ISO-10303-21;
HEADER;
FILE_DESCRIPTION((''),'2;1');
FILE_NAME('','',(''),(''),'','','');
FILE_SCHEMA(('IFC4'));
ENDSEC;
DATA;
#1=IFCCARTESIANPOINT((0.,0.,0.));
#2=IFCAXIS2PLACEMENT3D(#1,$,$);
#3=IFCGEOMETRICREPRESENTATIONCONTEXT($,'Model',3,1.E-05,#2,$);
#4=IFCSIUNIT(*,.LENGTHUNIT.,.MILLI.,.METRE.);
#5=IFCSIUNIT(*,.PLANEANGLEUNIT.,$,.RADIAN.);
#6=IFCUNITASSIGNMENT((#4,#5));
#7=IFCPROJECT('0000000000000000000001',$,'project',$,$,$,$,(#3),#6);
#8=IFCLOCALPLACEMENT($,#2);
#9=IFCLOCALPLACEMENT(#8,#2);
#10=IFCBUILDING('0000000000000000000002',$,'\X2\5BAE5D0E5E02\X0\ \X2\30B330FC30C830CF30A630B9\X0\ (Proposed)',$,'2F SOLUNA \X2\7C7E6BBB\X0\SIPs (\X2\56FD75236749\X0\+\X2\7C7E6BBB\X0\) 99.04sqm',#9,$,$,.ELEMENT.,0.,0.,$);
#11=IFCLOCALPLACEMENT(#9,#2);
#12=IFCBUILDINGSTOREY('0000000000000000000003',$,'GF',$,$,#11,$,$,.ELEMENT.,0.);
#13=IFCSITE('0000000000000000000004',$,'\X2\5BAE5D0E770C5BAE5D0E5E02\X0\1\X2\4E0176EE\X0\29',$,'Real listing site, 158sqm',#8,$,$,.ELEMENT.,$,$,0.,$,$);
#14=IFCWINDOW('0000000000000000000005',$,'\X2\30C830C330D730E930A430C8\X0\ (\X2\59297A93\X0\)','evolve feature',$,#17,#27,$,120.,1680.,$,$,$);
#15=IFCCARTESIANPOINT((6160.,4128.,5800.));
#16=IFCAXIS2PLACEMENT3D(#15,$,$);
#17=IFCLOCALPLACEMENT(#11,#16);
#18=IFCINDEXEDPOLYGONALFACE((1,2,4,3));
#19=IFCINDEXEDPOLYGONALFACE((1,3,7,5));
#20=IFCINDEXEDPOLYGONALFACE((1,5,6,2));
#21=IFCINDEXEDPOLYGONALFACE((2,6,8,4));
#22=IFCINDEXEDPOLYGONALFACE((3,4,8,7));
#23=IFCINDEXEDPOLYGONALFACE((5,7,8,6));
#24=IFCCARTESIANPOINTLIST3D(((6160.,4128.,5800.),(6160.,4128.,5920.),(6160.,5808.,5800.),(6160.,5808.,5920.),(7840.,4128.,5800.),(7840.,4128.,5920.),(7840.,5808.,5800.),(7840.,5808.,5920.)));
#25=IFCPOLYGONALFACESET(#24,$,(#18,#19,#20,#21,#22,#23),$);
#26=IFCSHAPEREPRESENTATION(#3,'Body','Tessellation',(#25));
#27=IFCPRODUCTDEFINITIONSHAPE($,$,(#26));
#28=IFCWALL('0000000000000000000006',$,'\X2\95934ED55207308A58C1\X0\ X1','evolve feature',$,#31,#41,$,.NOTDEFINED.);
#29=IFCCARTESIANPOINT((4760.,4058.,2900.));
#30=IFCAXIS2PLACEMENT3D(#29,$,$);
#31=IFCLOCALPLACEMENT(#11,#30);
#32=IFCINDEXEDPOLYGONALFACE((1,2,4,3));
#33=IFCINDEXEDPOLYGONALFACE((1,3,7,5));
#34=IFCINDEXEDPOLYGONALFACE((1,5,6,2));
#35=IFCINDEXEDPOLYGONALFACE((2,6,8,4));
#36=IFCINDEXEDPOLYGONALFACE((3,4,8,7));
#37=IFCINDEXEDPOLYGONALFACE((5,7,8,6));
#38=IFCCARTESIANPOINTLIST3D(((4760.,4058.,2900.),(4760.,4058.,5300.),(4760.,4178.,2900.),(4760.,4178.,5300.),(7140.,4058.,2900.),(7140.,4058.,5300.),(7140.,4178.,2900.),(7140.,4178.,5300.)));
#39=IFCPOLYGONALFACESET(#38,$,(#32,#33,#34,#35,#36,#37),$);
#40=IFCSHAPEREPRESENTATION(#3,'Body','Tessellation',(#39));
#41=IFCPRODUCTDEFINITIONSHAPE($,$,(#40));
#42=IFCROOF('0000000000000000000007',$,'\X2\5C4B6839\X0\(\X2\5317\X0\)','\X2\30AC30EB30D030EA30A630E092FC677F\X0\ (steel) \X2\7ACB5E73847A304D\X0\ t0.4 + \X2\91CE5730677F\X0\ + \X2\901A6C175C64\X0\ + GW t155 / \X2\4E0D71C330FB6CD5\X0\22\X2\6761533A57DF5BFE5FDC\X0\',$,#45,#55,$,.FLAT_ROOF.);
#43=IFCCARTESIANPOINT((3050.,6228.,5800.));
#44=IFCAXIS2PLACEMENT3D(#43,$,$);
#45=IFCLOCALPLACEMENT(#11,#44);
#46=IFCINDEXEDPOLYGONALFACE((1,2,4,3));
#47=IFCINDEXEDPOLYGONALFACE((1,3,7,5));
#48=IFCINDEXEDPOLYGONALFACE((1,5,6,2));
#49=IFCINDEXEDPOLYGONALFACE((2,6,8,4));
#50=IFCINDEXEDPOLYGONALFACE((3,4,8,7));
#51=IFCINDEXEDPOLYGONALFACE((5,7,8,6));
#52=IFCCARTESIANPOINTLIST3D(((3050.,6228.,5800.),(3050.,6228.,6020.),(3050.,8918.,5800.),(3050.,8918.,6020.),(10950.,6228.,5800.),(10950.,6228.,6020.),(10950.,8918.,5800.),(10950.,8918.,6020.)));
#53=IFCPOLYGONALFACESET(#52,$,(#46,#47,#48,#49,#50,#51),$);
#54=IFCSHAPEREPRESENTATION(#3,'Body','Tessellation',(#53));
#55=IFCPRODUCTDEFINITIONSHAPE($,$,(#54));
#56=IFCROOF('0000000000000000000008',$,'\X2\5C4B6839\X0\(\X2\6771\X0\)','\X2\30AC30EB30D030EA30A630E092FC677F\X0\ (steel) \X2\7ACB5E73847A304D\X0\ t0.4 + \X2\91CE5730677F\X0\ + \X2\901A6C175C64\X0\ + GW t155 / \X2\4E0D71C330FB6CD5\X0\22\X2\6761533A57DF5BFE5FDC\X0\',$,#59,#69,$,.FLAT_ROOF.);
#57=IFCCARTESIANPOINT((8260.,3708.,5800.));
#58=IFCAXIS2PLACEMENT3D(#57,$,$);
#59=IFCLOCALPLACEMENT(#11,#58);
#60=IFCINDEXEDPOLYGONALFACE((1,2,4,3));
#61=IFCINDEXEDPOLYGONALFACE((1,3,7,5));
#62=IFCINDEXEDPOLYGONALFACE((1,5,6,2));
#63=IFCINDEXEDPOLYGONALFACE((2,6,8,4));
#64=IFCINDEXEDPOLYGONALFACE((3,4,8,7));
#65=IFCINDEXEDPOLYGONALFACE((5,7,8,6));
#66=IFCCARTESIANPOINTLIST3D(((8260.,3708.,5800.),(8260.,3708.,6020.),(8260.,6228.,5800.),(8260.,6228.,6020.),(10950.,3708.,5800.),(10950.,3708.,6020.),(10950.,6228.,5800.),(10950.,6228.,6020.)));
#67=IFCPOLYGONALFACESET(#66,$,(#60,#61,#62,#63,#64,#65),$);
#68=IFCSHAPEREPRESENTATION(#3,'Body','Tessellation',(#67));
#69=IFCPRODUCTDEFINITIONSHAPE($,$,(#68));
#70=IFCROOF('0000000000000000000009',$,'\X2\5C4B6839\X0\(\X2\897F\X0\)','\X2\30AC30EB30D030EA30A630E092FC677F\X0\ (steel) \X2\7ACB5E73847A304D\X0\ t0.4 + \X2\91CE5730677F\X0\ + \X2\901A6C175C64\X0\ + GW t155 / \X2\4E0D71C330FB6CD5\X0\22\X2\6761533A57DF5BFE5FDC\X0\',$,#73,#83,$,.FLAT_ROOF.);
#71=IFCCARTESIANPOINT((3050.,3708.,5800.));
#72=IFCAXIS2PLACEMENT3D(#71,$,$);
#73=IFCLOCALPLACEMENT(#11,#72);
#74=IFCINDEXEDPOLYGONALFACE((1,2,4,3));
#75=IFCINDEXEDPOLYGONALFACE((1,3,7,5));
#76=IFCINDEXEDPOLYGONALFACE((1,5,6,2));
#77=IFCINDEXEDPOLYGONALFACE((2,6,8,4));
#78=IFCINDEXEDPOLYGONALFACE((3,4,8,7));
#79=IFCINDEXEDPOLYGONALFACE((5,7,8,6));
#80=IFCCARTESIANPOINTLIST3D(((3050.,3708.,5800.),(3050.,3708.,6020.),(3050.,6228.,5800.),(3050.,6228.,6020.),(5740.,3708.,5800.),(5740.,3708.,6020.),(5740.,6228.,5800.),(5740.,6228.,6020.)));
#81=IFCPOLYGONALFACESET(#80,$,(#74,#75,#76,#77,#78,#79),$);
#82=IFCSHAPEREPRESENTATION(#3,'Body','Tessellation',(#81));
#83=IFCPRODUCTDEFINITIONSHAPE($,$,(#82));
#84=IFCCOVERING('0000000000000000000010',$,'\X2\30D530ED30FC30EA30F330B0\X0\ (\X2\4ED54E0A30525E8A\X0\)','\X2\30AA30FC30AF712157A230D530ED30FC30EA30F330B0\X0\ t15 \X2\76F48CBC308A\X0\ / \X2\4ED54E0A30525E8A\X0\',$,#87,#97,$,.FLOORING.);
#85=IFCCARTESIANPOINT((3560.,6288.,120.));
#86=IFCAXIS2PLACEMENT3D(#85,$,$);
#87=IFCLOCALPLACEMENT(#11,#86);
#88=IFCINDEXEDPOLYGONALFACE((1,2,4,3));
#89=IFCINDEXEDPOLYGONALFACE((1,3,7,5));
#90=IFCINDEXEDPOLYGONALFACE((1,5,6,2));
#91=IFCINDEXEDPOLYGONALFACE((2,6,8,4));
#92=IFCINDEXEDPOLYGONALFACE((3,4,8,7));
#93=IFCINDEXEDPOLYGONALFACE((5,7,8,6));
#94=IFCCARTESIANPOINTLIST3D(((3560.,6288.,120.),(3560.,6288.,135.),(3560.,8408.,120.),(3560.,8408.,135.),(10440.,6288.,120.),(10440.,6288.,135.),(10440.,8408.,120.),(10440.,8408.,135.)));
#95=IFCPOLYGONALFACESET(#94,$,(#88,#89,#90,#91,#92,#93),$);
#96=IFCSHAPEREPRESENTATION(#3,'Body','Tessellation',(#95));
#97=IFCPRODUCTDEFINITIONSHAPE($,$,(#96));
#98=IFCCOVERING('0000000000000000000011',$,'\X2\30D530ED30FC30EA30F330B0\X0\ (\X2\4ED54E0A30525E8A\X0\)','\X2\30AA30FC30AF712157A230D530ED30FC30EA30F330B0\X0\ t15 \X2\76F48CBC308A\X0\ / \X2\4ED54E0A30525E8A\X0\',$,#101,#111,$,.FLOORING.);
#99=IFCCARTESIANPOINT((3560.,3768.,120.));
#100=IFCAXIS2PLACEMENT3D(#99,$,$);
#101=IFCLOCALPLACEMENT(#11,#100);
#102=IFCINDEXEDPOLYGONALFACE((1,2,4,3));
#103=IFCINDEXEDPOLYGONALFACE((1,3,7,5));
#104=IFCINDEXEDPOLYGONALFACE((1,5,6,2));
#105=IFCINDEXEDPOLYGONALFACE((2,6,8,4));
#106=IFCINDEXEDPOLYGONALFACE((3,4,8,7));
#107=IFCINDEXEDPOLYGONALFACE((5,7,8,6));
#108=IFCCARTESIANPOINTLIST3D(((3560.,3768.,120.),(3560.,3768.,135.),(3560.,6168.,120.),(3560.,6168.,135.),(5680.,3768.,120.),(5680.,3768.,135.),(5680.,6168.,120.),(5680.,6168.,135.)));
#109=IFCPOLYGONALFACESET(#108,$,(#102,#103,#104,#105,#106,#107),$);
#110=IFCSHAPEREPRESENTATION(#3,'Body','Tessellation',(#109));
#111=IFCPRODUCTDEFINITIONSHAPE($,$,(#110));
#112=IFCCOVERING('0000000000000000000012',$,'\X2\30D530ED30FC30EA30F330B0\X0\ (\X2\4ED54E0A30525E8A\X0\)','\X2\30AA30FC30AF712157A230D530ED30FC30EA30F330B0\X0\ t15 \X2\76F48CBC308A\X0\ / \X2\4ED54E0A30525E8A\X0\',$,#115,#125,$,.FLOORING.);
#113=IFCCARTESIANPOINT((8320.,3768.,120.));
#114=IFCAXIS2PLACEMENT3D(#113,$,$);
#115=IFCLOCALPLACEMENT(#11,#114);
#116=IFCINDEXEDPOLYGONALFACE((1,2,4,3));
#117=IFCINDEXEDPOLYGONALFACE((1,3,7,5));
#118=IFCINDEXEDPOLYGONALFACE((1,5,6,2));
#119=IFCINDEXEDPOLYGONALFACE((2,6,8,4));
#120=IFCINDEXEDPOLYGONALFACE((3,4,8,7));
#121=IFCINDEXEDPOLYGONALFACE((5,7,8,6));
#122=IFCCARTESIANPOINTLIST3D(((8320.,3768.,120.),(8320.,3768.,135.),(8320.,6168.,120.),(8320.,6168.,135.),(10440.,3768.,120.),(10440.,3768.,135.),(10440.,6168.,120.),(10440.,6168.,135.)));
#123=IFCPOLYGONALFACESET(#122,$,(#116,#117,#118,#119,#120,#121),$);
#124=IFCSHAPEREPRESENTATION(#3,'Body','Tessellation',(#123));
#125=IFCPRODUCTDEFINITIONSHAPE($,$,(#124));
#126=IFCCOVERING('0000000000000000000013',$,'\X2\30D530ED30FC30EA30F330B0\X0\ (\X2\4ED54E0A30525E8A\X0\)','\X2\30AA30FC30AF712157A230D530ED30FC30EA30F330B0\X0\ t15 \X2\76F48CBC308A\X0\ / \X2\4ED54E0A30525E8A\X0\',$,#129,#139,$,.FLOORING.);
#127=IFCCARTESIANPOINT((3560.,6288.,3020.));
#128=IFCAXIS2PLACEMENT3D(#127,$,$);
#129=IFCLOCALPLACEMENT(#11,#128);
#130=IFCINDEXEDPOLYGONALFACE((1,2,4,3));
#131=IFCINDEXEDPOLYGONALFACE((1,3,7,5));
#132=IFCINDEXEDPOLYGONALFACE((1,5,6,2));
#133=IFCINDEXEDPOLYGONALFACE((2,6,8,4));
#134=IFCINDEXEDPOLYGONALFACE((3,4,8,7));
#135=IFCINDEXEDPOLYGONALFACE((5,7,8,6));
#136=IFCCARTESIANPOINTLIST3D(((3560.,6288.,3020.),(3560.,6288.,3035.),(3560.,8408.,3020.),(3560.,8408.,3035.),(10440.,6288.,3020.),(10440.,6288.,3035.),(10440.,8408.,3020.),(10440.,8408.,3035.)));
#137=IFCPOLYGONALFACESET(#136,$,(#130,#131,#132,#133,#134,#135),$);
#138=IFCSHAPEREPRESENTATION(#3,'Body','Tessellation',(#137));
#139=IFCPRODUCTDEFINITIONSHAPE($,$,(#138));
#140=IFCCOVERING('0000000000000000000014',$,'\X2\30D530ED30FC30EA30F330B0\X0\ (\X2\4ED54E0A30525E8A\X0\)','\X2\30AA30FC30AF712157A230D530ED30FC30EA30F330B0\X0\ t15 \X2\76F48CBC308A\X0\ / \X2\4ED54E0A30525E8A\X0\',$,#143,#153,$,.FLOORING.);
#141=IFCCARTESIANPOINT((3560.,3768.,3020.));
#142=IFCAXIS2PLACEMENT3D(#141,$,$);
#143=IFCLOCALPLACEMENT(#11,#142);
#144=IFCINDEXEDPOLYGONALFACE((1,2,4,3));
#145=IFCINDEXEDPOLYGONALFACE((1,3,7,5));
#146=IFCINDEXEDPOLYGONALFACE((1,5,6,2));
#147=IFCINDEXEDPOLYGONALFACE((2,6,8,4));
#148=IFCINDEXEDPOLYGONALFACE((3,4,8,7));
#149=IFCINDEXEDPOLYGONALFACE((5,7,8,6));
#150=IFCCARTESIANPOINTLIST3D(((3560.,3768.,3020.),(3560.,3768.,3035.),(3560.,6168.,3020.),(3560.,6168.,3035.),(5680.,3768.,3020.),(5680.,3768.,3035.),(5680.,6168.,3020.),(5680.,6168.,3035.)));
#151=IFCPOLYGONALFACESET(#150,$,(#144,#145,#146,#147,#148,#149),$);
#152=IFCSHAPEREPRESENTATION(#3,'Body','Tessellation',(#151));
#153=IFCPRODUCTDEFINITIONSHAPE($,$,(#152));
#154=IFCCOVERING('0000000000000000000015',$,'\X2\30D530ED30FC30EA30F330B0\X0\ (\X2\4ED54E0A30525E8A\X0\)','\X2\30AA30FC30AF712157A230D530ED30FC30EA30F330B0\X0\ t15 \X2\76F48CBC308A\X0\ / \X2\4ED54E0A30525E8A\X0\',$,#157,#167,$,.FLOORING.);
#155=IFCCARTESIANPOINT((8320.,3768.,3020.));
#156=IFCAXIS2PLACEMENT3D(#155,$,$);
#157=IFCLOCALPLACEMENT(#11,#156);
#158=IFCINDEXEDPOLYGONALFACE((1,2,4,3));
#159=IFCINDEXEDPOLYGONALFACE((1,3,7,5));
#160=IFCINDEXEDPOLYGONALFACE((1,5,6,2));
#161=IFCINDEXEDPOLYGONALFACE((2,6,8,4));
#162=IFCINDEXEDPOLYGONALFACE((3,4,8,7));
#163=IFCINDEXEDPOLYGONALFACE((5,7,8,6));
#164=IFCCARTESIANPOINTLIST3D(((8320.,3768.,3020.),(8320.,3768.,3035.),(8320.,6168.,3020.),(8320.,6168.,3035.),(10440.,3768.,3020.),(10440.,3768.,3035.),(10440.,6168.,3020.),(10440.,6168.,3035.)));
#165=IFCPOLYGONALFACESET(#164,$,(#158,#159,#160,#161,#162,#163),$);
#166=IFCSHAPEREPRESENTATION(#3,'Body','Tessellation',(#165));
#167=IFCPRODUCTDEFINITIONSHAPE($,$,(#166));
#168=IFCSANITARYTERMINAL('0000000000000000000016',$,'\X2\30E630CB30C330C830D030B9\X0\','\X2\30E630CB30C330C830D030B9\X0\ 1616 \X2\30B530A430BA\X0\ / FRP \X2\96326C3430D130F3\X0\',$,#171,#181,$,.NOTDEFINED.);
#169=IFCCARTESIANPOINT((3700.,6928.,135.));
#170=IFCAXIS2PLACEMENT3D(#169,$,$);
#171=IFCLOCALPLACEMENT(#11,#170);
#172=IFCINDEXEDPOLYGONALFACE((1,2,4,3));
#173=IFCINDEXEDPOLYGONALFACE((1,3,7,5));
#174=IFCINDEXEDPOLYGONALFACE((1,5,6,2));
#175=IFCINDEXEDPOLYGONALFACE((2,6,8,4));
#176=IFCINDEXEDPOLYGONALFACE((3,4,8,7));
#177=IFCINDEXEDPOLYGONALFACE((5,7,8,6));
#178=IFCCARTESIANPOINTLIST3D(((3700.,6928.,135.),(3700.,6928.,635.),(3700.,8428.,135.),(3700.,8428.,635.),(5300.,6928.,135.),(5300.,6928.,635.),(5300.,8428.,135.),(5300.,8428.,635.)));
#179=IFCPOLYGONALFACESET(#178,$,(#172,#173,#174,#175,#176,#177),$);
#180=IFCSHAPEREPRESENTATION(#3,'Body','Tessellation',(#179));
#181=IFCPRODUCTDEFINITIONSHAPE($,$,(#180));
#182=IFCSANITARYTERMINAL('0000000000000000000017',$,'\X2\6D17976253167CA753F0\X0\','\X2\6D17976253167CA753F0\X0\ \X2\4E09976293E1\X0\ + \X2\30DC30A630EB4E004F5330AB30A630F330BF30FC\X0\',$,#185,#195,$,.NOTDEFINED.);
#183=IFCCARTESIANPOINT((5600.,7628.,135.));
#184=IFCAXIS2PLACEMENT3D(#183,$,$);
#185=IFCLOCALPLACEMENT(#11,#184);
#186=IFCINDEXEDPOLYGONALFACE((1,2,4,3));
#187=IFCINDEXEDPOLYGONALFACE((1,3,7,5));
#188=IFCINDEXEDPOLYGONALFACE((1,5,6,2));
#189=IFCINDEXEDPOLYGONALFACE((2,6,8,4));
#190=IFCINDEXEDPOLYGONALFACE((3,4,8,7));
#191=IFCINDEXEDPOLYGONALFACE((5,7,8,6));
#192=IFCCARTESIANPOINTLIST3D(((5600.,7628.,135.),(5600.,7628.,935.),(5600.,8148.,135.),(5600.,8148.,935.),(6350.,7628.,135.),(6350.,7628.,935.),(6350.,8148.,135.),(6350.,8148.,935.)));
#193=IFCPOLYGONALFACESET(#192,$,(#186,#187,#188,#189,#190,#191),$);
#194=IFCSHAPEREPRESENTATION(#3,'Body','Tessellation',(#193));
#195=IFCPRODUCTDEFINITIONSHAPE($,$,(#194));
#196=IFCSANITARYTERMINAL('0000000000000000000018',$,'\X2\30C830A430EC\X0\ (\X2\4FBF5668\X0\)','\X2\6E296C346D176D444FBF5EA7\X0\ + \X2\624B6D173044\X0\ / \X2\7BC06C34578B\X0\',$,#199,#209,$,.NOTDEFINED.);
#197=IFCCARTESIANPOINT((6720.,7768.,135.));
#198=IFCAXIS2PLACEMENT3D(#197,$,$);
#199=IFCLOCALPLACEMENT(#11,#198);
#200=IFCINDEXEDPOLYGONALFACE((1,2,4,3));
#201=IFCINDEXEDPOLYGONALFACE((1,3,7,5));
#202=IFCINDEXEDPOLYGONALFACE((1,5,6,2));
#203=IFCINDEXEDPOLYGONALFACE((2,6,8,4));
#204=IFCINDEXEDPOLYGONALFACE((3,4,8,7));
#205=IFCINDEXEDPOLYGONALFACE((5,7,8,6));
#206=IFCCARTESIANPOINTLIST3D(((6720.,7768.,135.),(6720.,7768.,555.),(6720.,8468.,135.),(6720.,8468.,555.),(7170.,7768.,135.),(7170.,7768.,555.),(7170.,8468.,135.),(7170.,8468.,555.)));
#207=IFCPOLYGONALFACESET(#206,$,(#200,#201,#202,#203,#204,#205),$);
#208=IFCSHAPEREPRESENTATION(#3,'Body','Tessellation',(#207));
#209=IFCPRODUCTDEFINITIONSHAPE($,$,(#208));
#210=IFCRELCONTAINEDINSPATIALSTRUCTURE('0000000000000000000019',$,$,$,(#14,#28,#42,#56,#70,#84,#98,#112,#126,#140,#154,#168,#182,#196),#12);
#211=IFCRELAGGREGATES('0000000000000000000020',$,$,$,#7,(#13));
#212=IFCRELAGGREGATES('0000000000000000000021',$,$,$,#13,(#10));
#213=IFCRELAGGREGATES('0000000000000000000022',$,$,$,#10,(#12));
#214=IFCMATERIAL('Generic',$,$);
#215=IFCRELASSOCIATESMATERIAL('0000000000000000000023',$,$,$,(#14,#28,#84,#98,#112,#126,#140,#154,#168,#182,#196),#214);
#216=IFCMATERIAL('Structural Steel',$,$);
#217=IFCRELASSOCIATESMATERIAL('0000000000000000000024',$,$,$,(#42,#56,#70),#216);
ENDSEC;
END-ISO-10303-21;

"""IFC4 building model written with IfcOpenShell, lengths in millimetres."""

from ifc_helpers import new_model, si_unit, frame, frame_2d, origin, place, context, project, spatial, rectangle, extrude, material, element, save


model = new_model("IFC4")

# Units and contexts
model_context = context("Model", 3, precision=1e-05, world=origin())
ifc_project = project(units=[si_unit("LENGTHUNIT", "METRE", prefix="MILLI"), si_unit("PLANEANGLEUNIT", "RADIAN")], contexts=[model_context])

# Site, building, storey
site_placement = place(None, origin())
site = spatial("IfcSite", under=ifc_project, at=site_placement, Name="宮崎県宮崎市1丁目29", ObjectType="Real listing site, 158sqm", CompositionType="ELEMENT", RefElevation=0.0)
building_placement = place(site_placement, origin())
building = spatial("IfcBuilding", under=site, at=building_placement, Name="宮崎市 コートハウス (Proposed)", ObjectType="2F SOLUNA 籾殻SIPs (国産杉+籾殻) 99.04sqm", CompositionType="ELEMENT", ElevationOfRefHeight=0.0, ElevationOfTerrain=0.0)
storey_placement = place(building_placement, origin())
storey = spatial("IfcBuildingStorey", under=building, at=storey_placement, Name="GF", CompositionType="ELEMENT", Elevation=0.0)

# Window
ifc_material_1 = material(Name="Generic")
window_1_placement = place(storey_placement, frame((6160.0, 4128.0, 5800.0)))
element("IfcWindow", 1, at=window_1_placement, inside=storey, material=ifc_material_1, Name="トップライト (天窓)", Description="evolve feature", OverallHeight=120.0, OverallWidth=1680.0, context=model_context, shape_type="SweptSolid", body=[
    extrude(rectangle(XDim=1680.0, YDim=1680.0, at=frame_2d((840.0, 840.0))), frame((6160.0, 4128.0, 5800.0)), (0.0, 0.0, 1.0), 120.0),
])

# Wall
wall_1_placement = place(storey_placement, frame((4760.0, 4058.0, 2900.0)))
element("IfcWall", 2, at=wall_1_placement, inside=storey, material=ifc_material_1, Name="間仕切り壁 X1", Description="evolve feature", PredefinedType="NOTDEFINED", context=model_context, shape_type="SweptSolid", body=[
    extrude(rectangle(XDim=2380.0, YDim=120.0, at=frame_2d((1190.0, 60.0))), frame((4760.0, 4058.0, 2900.0)), (0.0, 0.0, 1.0), 2400.0),
])

# Roofs
ifc_material_2 = material(Name="Structural Steel")
roof_1_placement = place(storey_placement, frame((3050.0, 6228.0, 5800.0)))
element("IfcRoof", 3, at=roof_1_placement, inside=storey, material=ifc_material_2, Name="屋根(北)", Description="ガルバリウム鋼板 (steel) 立平葺き t0.4 + 野地板 + 通気層 + GW t155 / 不燃・法22条区域対応", PredefinedType="FLAT_ROOF", context=model_context, shape_type="SweptSolid", body=[
    extrude(rectangle(XDim=7900.0, YDim=2690.0, at=frame_2d((3950.0, 1345.0))), frame((3050.0, 6228.0, 5800.0)), (0.0, 0.0, 1.0), 220.0),
])
roof_2_placement = place(storey_placement, frame((8260.0, 3708.0, 5800.0)))
element("IfcRoof", 4, at=roof_2_placement, inside=storey, material=ifc_material_2, Name="屋根(東)", Description="ガルバリウム鋼板 (steel) 立平葺き t0.4 + 野地板 + 通気層 + GW t155 / 不燃・法22条区域対応", PredefinedType="FLAT_ROOF", context=model_context, shape_type="SweptSolid", body=[
    extrude(rectangle(XDim=2690.0, YDim=2520.0, at=frame_2d((1345.0, 1260.0))), frame((8260.0, 3708.0, 5800.0)), (0.0, 0.0, 1.0), 220.0),
])
roof_3_placement = place(storey_placement, frame((3050.0, 3708.0, 5800.0)))
element("IfcRoof", 5, at=roof_3_placement, inside=storey, material=ifc_material_2, Name="屋根(西)", Description="ガルバリウム鋼板 (steel) 立平葺き t0.4 + 野地板 + 通気層 + GW t155 / 不燃・法22条区域対応", PredefinedType="FLAT_ROOF", context=model_context, shape_type="SweptSolid", body=[
    extrude(rectangle(XDim=2690.0, YDim=2520.0, at=frame_2d((1345.0, 1260.0))), frame((3050.0, 3708.0, 5800.0)), (0.0, 0.0, 1.0), 220.0),
])

# Coverings
covering_1_placement = place(storey_placement, frame((3560.0, 6288.0, 120.0)))
element("IfcCovering", 6, at=covering_1_placement, inside=storey, material=ifc_material_1, Name="フローリング (仕上げ床)", Description="オーク無垢フローリング t15 直貼り / 仕上げ床", PredefinedType="FLOORING", context=model_context, shape_type="SweptSolid", body=[
    extrude(rectangle(XDim=6880.0, YDim=2120.0, at=frame_2d((3440.0, 1060.0))), frame((3560.0, 6288.0, 120.0)), (0.0, 0.0, 1.0), 15.0),
])
covering_2_placement = place(storey_placement, frame((3560.0, 3768.0, 120.0)))
element("IfcCovering", 7, at=covering_2_placement, inside=storey, material=ifc_material_1, Name="フローリング (仕上げ床)", Description="オーク無垢フローリング t15 直貼り / 仕上げ床", PredefinedType="FLOORING", context=model_context, shape_type="SweptSolid", body=[
    extrude(rectangle(XDim=2120.0, YDim=2400.0, at=frame_2d((1060.0, 1200.0))), frame((3560.0, 3768.0, 120.0)), (0.0, 0.0, 1.0), 15.0),
])
covering_3_placement = place(storey_placement, frame((8320.0, 3768.0, 120.0)))
element("IfcCovering", 8, at=covering_3_placement, inside=storey, material=ifc_material_1, Name="フローリング (仕上げ床)", Description="オーク無垢フローリング t15 直貼り / 仕上げ床", PredefinedType="FLOORING", context=model_context, shape_type="SweptSolid", body=[
    extrude(rectangle(XDim=2120.0, YDim=2400.0, at=frame_2d((1060.0, 1200.0))), frame((8320.0, 3768.0, 120.0)), (0.0, 0.0, 1.0), 15.0),
])
covering_4_placement = place(storey_placement, frame((3560.0, 6288.0, 3020.0)))
element("IfcCovering", 9, at=covering_4_placement, inside=storey, material=ifc_material_1, Name="フローリング (仕上げ床)", Description="オーク無垢フローリング t15 直貼り / 仕上げ床", PredefinedType="FLOORING", context=model_context, shape_type="SweptSolid", body=[
    extrude(rectangle(XDim=6880.0, YDim=2120.0, at=frame_2d((3440.0, 1060.0))), frame((3560.0, 6288.0, 3020.0)), (0.0, 0.0, 1.0), 15.0),
])
covering_5_placement = place(storey_placement, frame((3560.0, 3768.0, 3020.0)))
element("IfcCovering", 10, at=covering_5_placement, inside=storey, material=ifc_material_1, Name="フローリング (仕上げ床)", Description="オーク無垢フローリング t15 直貼り / 仕上げ床", PredefinedType="FLOORING", context=model_context, shape_type="SweptSolid", body=[
    extrude(rectangle(XDim=2120.0, YDim=2400.0, at=frame_2d((1060.0, 1200.0))), frame((3560.0, 3768.0, 3020.0)), (0.0, 0.0, 1.0), 15.0),
])
covering_6_placement = place(storey_placement, frame((8320.0, 3768.0, 3020.0)))
element("IfcCovering", 11, at=covering_6_placement, inside=storey, material=ifc_material_1, Name="フローリング (仕上げ床)", Description="オーク無垢フローリング t15 直貼り / 仕上げ床", PredefinedType="FLOORING", context=model_context, shape_type="SweptSolid", body=[
    extrude(rectangle(XDim=2120.0, YDim=2400.0, at=frame_2d((1060.0, 1200.0))), frame((8320.0, 3768.0, 3020.0)), (0.0, 0.0, 1.0), 15.0),
])

# Sanitary terminals
sanitary_terminal_1_placement = place(storey_placement, frame((3700.0, 6928.0, 135.0)))
element("IfcSanitaryTerminal", 12, at=sanitary_terminal_1_placement, inside=storey, material=ifc_material_1, Name="ユニットバス", Description="ユニットバス 1616 サイズ / FRP 防水パン", PredefinedType="NOTDEFINED", context=model_context, shape_type="SweptSolid", body=[
    extrude(rectangle(XDim=1600.0, YDim=1500.0, at=frame_2d((800.0, 750.0))), frame((3700.0, 6928.0, 135.0)), (0.0, 0.0, 1.0), 500.0),
])
sanitary_terminal_2_placement = place(storey_placement, frame((5600.0, 7628.0, 135.0)))
element("IfcSanitaryTerminal", 13, at=sanitary_terminal_2_placement, inside=storey, material=ifc_material_1, Name="洗面化粧台", Description="洗面化粧台 三面鏡 + ボウル一体カウンター", PredefinedType="NOTDEFINED", context=model_context, shape_type="SweptSolid", body=[
    extrude(rectangle(XDim=750.0, YDim=520.0, at=frame_2d((375.0, 260.0))), frame((5600.0, 7628.0, 135.0)), (0.0, 0.0, 1.0), 800.0),
])
sanitary_terminal_3_placement = place(storey_placement, frame((6720.0, 7768.0, 135.0)))
element("IfcSanitaryTerminal", 14, at=sanitary_terminal_3_placement, inside=storey, material=ifc_material_1, Name="トイレ (便器)", Description="温水洗浄便座 + 手洗い / 節水型", PredefinedType="NOTDEFINED", context=model_context, shape_type="SweptSolid", body=[
    extrude(rectangle(XDim=450.0, YDim=700.0, at=frame_2d((225.0, 350.0))), frame((6720.0, 7768.0, 135.0)), (0.0, 0.0, 1.0), 420.0),
])

save(model, "model.ifc")
